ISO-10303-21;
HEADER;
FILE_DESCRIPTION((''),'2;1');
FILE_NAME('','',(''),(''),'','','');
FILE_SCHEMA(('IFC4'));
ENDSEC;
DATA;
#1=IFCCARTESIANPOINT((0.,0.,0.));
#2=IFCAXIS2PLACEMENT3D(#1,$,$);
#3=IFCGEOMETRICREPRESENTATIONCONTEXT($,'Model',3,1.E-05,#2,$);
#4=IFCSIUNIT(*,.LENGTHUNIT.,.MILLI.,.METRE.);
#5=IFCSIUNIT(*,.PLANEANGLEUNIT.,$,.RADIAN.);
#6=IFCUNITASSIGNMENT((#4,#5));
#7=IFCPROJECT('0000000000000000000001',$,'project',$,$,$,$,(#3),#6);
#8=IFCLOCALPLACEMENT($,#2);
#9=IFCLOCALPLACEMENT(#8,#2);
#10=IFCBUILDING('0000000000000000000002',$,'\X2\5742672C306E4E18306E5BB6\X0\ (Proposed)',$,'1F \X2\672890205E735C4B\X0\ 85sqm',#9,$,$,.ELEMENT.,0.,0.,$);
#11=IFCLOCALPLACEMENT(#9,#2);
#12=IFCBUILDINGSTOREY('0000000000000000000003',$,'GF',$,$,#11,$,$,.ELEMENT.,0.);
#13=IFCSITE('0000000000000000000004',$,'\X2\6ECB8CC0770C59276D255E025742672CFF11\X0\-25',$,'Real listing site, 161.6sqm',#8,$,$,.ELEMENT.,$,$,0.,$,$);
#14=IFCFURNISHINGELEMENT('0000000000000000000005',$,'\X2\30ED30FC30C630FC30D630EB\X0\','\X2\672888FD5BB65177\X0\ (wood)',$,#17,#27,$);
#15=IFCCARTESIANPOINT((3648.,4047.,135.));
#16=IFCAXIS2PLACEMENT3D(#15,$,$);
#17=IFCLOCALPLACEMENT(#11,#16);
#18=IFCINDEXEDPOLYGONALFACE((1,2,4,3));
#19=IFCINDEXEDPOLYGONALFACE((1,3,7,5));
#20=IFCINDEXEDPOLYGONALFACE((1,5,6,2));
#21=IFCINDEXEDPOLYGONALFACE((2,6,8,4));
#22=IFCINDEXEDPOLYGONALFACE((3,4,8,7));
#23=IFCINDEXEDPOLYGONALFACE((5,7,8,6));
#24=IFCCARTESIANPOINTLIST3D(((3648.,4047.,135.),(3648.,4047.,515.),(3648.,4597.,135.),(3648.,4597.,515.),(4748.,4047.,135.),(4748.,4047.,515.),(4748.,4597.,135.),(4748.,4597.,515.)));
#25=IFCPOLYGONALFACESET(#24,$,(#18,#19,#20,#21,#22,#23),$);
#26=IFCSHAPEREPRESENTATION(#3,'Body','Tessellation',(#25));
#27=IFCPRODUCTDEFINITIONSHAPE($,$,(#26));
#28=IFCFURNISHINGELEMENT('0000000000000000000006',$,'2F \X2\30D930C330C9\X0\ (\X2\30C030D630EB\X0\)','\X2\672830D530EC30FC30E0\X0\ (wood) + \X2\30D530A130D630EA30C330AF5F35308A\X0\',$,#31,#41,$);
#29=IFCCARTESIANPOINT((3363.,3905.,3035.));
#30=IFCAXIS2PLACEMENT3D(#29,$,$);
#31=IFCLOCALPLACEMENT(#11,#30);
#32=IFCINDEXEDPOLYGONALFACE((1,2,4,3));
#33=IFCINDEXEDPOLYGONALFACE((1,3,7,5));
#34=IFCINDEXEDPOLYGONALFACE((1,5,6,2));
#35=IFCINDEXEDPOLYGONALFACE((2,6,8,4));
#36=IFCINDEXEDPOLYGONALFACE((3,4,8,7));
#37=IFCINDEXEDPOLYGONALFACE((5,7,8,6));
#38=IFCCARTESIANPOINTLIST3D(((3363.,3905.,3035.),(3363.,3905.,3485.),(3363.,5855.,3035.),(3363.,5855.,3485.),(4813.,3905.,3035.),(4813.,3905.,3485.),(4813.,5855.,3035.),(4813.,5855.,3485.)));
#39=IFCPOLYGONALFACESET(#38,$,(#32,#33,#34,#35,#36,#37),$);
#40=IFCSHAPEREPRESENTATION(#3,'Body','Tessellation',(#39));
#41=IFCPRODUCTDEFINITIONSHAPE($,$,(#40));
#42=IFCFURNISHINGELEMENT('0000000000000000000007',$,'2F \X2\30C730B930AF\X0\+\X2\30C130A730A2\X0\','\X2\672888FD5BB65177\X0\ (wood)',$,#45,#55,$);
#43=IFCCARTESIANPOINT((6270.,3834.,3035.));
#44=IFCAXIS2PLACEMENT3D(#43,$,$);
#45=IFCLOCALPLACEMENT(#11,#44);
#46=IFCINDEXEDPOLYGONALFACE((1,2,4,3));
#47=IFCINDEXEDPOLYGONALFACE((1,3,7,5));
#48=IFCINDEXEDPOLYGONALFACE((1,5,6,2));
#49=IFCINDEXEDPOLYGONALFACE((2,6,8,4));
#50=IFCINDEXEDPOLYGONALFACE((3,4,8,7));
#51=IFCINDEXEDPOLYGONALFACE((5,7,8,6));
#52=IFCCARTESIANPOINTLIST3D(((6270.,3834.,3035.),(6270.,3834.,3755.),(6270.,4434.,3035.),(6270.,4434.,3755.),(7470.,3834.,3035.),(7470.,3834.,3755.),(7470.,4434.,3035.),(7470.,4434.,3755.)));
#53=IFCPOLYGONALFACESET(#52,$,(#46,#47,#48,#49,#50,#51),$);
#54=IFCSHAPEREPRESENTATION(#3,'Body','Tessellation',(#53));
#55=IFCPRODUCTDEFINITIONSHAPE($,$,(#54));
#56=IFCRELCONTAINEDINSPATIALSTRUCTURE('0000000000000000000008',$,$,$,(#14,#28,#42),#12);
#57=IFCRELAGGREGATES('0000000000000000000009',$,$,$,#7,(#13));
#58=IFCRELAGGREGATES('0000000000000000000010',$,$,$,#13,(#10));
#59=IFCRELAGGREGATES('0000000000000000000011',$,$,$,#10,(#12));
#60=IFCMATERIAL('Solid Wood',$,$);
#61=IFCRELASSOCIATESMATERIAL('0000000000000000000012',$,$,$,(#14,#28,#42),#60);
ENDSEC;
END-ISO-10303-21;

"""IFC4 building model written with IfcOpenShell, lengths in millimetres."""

from ifc_helpers import new_model, si_unit, frame, frame_2d, origin, place, context, project, spatial, rectangle, extrude, material, element, save


model = new_model("IFC4")

# Units and contexts
model_context = context("Model", 3, precision=1e-05, world=origin())
ifc_project = project(units=[si_unit("LENGTHUNIT", "METRE", prefix="MILLI"), si_unit("PLANEANGLEUNIT", "RADIAN")], contexts=[model_context])

# Site, building, storey
site_placement = place(None, origin())
site = spatial("IfcSite", under=ifc_project, at=site_placement, Name="滋賀県大津市坂本１-25", ObjectType="Real listing site, 161.6sqm", CompositionType="ELEMENT", RefElevation=0.0)
building_placement = place(site_placement, origin())
building = spatial("IfcBuilding", under=site, at=building_placement, Name="坂本の丘の家 (Proposed)", ObjectType="1F 木造平屋 85sqm", CompositionType="ELEMENT", ElevationOfRefHeight=0.0, ElevationOfTerrain=0.0)
storey_placement = place(building_placement, origin())
storey = spatial("IfcBuildingStorey", under=building, at=storey_placement, Name="GF", CompositionType="ELEMENT", Elevation=0.0)

# Shared definitions
ifc_material_1 = material(Name="Solid Wood")

# Furnishing elements
furnishing_1_placement = place(storey_placement, frame((3648.0, 4047.0, 135.0)))
element("IfcFurnishingElement", 1, at=furnishing_1_placement, inside=storey, material=ifc_material_1, Name="ローテーブル", Description="木製家具 (wood)", context=model_context, shape_type="SweptSolid", body=[
    extrude(rectangle(XDim=1100.0, YDim=550.0, at=frame_2d((550.0, 275.0))), frame((3648.0, 4047.0, 135.0)), (0.0, 0.0, 1.0), 380.0),
])
furnishing_2_placement = place(storey_placement, frame((3363.0, 3905.0, 3035.0)))
element("IfcFurnishingElement", 2, at=furnishing_2_placement, inside=storey, material=ifc_material_1, Name="2F ベッド (ダブル)", Description="木フレーム (wood) + ファブリック張り", context=model_context, shape_type="SweptSolid", body=[
    extrude(rectangle(XDim=1450.0, YDim=1950.0, at=frame_2d((725.0, 975.0))), frame((3363.0, 3905.0, 3035.0)), (0.0, 0.0, 1.0), 450.0),
])
furnishing_3_placement = place(storey_placement, frame((6270.0, 3834.0, 3035.0)))
element("IfcFurnishingElement", 3, at=furnishing_3_placement, inside=storey, material=ifc_material_1, Name="2F デスク+チェア", Description="木製家具 (wood)", context=model_context, shape_type="SweptSolid", body=[
    extrude(rectangle(XDim=1200.0, YDim=600.0, at=frame_2d((600.0, 300.0))), frame((6270.0, 3834.0, 3035.0)), (0.0, 0.0, 1.0), 720.0),
])

save(model, "model.ifc")
